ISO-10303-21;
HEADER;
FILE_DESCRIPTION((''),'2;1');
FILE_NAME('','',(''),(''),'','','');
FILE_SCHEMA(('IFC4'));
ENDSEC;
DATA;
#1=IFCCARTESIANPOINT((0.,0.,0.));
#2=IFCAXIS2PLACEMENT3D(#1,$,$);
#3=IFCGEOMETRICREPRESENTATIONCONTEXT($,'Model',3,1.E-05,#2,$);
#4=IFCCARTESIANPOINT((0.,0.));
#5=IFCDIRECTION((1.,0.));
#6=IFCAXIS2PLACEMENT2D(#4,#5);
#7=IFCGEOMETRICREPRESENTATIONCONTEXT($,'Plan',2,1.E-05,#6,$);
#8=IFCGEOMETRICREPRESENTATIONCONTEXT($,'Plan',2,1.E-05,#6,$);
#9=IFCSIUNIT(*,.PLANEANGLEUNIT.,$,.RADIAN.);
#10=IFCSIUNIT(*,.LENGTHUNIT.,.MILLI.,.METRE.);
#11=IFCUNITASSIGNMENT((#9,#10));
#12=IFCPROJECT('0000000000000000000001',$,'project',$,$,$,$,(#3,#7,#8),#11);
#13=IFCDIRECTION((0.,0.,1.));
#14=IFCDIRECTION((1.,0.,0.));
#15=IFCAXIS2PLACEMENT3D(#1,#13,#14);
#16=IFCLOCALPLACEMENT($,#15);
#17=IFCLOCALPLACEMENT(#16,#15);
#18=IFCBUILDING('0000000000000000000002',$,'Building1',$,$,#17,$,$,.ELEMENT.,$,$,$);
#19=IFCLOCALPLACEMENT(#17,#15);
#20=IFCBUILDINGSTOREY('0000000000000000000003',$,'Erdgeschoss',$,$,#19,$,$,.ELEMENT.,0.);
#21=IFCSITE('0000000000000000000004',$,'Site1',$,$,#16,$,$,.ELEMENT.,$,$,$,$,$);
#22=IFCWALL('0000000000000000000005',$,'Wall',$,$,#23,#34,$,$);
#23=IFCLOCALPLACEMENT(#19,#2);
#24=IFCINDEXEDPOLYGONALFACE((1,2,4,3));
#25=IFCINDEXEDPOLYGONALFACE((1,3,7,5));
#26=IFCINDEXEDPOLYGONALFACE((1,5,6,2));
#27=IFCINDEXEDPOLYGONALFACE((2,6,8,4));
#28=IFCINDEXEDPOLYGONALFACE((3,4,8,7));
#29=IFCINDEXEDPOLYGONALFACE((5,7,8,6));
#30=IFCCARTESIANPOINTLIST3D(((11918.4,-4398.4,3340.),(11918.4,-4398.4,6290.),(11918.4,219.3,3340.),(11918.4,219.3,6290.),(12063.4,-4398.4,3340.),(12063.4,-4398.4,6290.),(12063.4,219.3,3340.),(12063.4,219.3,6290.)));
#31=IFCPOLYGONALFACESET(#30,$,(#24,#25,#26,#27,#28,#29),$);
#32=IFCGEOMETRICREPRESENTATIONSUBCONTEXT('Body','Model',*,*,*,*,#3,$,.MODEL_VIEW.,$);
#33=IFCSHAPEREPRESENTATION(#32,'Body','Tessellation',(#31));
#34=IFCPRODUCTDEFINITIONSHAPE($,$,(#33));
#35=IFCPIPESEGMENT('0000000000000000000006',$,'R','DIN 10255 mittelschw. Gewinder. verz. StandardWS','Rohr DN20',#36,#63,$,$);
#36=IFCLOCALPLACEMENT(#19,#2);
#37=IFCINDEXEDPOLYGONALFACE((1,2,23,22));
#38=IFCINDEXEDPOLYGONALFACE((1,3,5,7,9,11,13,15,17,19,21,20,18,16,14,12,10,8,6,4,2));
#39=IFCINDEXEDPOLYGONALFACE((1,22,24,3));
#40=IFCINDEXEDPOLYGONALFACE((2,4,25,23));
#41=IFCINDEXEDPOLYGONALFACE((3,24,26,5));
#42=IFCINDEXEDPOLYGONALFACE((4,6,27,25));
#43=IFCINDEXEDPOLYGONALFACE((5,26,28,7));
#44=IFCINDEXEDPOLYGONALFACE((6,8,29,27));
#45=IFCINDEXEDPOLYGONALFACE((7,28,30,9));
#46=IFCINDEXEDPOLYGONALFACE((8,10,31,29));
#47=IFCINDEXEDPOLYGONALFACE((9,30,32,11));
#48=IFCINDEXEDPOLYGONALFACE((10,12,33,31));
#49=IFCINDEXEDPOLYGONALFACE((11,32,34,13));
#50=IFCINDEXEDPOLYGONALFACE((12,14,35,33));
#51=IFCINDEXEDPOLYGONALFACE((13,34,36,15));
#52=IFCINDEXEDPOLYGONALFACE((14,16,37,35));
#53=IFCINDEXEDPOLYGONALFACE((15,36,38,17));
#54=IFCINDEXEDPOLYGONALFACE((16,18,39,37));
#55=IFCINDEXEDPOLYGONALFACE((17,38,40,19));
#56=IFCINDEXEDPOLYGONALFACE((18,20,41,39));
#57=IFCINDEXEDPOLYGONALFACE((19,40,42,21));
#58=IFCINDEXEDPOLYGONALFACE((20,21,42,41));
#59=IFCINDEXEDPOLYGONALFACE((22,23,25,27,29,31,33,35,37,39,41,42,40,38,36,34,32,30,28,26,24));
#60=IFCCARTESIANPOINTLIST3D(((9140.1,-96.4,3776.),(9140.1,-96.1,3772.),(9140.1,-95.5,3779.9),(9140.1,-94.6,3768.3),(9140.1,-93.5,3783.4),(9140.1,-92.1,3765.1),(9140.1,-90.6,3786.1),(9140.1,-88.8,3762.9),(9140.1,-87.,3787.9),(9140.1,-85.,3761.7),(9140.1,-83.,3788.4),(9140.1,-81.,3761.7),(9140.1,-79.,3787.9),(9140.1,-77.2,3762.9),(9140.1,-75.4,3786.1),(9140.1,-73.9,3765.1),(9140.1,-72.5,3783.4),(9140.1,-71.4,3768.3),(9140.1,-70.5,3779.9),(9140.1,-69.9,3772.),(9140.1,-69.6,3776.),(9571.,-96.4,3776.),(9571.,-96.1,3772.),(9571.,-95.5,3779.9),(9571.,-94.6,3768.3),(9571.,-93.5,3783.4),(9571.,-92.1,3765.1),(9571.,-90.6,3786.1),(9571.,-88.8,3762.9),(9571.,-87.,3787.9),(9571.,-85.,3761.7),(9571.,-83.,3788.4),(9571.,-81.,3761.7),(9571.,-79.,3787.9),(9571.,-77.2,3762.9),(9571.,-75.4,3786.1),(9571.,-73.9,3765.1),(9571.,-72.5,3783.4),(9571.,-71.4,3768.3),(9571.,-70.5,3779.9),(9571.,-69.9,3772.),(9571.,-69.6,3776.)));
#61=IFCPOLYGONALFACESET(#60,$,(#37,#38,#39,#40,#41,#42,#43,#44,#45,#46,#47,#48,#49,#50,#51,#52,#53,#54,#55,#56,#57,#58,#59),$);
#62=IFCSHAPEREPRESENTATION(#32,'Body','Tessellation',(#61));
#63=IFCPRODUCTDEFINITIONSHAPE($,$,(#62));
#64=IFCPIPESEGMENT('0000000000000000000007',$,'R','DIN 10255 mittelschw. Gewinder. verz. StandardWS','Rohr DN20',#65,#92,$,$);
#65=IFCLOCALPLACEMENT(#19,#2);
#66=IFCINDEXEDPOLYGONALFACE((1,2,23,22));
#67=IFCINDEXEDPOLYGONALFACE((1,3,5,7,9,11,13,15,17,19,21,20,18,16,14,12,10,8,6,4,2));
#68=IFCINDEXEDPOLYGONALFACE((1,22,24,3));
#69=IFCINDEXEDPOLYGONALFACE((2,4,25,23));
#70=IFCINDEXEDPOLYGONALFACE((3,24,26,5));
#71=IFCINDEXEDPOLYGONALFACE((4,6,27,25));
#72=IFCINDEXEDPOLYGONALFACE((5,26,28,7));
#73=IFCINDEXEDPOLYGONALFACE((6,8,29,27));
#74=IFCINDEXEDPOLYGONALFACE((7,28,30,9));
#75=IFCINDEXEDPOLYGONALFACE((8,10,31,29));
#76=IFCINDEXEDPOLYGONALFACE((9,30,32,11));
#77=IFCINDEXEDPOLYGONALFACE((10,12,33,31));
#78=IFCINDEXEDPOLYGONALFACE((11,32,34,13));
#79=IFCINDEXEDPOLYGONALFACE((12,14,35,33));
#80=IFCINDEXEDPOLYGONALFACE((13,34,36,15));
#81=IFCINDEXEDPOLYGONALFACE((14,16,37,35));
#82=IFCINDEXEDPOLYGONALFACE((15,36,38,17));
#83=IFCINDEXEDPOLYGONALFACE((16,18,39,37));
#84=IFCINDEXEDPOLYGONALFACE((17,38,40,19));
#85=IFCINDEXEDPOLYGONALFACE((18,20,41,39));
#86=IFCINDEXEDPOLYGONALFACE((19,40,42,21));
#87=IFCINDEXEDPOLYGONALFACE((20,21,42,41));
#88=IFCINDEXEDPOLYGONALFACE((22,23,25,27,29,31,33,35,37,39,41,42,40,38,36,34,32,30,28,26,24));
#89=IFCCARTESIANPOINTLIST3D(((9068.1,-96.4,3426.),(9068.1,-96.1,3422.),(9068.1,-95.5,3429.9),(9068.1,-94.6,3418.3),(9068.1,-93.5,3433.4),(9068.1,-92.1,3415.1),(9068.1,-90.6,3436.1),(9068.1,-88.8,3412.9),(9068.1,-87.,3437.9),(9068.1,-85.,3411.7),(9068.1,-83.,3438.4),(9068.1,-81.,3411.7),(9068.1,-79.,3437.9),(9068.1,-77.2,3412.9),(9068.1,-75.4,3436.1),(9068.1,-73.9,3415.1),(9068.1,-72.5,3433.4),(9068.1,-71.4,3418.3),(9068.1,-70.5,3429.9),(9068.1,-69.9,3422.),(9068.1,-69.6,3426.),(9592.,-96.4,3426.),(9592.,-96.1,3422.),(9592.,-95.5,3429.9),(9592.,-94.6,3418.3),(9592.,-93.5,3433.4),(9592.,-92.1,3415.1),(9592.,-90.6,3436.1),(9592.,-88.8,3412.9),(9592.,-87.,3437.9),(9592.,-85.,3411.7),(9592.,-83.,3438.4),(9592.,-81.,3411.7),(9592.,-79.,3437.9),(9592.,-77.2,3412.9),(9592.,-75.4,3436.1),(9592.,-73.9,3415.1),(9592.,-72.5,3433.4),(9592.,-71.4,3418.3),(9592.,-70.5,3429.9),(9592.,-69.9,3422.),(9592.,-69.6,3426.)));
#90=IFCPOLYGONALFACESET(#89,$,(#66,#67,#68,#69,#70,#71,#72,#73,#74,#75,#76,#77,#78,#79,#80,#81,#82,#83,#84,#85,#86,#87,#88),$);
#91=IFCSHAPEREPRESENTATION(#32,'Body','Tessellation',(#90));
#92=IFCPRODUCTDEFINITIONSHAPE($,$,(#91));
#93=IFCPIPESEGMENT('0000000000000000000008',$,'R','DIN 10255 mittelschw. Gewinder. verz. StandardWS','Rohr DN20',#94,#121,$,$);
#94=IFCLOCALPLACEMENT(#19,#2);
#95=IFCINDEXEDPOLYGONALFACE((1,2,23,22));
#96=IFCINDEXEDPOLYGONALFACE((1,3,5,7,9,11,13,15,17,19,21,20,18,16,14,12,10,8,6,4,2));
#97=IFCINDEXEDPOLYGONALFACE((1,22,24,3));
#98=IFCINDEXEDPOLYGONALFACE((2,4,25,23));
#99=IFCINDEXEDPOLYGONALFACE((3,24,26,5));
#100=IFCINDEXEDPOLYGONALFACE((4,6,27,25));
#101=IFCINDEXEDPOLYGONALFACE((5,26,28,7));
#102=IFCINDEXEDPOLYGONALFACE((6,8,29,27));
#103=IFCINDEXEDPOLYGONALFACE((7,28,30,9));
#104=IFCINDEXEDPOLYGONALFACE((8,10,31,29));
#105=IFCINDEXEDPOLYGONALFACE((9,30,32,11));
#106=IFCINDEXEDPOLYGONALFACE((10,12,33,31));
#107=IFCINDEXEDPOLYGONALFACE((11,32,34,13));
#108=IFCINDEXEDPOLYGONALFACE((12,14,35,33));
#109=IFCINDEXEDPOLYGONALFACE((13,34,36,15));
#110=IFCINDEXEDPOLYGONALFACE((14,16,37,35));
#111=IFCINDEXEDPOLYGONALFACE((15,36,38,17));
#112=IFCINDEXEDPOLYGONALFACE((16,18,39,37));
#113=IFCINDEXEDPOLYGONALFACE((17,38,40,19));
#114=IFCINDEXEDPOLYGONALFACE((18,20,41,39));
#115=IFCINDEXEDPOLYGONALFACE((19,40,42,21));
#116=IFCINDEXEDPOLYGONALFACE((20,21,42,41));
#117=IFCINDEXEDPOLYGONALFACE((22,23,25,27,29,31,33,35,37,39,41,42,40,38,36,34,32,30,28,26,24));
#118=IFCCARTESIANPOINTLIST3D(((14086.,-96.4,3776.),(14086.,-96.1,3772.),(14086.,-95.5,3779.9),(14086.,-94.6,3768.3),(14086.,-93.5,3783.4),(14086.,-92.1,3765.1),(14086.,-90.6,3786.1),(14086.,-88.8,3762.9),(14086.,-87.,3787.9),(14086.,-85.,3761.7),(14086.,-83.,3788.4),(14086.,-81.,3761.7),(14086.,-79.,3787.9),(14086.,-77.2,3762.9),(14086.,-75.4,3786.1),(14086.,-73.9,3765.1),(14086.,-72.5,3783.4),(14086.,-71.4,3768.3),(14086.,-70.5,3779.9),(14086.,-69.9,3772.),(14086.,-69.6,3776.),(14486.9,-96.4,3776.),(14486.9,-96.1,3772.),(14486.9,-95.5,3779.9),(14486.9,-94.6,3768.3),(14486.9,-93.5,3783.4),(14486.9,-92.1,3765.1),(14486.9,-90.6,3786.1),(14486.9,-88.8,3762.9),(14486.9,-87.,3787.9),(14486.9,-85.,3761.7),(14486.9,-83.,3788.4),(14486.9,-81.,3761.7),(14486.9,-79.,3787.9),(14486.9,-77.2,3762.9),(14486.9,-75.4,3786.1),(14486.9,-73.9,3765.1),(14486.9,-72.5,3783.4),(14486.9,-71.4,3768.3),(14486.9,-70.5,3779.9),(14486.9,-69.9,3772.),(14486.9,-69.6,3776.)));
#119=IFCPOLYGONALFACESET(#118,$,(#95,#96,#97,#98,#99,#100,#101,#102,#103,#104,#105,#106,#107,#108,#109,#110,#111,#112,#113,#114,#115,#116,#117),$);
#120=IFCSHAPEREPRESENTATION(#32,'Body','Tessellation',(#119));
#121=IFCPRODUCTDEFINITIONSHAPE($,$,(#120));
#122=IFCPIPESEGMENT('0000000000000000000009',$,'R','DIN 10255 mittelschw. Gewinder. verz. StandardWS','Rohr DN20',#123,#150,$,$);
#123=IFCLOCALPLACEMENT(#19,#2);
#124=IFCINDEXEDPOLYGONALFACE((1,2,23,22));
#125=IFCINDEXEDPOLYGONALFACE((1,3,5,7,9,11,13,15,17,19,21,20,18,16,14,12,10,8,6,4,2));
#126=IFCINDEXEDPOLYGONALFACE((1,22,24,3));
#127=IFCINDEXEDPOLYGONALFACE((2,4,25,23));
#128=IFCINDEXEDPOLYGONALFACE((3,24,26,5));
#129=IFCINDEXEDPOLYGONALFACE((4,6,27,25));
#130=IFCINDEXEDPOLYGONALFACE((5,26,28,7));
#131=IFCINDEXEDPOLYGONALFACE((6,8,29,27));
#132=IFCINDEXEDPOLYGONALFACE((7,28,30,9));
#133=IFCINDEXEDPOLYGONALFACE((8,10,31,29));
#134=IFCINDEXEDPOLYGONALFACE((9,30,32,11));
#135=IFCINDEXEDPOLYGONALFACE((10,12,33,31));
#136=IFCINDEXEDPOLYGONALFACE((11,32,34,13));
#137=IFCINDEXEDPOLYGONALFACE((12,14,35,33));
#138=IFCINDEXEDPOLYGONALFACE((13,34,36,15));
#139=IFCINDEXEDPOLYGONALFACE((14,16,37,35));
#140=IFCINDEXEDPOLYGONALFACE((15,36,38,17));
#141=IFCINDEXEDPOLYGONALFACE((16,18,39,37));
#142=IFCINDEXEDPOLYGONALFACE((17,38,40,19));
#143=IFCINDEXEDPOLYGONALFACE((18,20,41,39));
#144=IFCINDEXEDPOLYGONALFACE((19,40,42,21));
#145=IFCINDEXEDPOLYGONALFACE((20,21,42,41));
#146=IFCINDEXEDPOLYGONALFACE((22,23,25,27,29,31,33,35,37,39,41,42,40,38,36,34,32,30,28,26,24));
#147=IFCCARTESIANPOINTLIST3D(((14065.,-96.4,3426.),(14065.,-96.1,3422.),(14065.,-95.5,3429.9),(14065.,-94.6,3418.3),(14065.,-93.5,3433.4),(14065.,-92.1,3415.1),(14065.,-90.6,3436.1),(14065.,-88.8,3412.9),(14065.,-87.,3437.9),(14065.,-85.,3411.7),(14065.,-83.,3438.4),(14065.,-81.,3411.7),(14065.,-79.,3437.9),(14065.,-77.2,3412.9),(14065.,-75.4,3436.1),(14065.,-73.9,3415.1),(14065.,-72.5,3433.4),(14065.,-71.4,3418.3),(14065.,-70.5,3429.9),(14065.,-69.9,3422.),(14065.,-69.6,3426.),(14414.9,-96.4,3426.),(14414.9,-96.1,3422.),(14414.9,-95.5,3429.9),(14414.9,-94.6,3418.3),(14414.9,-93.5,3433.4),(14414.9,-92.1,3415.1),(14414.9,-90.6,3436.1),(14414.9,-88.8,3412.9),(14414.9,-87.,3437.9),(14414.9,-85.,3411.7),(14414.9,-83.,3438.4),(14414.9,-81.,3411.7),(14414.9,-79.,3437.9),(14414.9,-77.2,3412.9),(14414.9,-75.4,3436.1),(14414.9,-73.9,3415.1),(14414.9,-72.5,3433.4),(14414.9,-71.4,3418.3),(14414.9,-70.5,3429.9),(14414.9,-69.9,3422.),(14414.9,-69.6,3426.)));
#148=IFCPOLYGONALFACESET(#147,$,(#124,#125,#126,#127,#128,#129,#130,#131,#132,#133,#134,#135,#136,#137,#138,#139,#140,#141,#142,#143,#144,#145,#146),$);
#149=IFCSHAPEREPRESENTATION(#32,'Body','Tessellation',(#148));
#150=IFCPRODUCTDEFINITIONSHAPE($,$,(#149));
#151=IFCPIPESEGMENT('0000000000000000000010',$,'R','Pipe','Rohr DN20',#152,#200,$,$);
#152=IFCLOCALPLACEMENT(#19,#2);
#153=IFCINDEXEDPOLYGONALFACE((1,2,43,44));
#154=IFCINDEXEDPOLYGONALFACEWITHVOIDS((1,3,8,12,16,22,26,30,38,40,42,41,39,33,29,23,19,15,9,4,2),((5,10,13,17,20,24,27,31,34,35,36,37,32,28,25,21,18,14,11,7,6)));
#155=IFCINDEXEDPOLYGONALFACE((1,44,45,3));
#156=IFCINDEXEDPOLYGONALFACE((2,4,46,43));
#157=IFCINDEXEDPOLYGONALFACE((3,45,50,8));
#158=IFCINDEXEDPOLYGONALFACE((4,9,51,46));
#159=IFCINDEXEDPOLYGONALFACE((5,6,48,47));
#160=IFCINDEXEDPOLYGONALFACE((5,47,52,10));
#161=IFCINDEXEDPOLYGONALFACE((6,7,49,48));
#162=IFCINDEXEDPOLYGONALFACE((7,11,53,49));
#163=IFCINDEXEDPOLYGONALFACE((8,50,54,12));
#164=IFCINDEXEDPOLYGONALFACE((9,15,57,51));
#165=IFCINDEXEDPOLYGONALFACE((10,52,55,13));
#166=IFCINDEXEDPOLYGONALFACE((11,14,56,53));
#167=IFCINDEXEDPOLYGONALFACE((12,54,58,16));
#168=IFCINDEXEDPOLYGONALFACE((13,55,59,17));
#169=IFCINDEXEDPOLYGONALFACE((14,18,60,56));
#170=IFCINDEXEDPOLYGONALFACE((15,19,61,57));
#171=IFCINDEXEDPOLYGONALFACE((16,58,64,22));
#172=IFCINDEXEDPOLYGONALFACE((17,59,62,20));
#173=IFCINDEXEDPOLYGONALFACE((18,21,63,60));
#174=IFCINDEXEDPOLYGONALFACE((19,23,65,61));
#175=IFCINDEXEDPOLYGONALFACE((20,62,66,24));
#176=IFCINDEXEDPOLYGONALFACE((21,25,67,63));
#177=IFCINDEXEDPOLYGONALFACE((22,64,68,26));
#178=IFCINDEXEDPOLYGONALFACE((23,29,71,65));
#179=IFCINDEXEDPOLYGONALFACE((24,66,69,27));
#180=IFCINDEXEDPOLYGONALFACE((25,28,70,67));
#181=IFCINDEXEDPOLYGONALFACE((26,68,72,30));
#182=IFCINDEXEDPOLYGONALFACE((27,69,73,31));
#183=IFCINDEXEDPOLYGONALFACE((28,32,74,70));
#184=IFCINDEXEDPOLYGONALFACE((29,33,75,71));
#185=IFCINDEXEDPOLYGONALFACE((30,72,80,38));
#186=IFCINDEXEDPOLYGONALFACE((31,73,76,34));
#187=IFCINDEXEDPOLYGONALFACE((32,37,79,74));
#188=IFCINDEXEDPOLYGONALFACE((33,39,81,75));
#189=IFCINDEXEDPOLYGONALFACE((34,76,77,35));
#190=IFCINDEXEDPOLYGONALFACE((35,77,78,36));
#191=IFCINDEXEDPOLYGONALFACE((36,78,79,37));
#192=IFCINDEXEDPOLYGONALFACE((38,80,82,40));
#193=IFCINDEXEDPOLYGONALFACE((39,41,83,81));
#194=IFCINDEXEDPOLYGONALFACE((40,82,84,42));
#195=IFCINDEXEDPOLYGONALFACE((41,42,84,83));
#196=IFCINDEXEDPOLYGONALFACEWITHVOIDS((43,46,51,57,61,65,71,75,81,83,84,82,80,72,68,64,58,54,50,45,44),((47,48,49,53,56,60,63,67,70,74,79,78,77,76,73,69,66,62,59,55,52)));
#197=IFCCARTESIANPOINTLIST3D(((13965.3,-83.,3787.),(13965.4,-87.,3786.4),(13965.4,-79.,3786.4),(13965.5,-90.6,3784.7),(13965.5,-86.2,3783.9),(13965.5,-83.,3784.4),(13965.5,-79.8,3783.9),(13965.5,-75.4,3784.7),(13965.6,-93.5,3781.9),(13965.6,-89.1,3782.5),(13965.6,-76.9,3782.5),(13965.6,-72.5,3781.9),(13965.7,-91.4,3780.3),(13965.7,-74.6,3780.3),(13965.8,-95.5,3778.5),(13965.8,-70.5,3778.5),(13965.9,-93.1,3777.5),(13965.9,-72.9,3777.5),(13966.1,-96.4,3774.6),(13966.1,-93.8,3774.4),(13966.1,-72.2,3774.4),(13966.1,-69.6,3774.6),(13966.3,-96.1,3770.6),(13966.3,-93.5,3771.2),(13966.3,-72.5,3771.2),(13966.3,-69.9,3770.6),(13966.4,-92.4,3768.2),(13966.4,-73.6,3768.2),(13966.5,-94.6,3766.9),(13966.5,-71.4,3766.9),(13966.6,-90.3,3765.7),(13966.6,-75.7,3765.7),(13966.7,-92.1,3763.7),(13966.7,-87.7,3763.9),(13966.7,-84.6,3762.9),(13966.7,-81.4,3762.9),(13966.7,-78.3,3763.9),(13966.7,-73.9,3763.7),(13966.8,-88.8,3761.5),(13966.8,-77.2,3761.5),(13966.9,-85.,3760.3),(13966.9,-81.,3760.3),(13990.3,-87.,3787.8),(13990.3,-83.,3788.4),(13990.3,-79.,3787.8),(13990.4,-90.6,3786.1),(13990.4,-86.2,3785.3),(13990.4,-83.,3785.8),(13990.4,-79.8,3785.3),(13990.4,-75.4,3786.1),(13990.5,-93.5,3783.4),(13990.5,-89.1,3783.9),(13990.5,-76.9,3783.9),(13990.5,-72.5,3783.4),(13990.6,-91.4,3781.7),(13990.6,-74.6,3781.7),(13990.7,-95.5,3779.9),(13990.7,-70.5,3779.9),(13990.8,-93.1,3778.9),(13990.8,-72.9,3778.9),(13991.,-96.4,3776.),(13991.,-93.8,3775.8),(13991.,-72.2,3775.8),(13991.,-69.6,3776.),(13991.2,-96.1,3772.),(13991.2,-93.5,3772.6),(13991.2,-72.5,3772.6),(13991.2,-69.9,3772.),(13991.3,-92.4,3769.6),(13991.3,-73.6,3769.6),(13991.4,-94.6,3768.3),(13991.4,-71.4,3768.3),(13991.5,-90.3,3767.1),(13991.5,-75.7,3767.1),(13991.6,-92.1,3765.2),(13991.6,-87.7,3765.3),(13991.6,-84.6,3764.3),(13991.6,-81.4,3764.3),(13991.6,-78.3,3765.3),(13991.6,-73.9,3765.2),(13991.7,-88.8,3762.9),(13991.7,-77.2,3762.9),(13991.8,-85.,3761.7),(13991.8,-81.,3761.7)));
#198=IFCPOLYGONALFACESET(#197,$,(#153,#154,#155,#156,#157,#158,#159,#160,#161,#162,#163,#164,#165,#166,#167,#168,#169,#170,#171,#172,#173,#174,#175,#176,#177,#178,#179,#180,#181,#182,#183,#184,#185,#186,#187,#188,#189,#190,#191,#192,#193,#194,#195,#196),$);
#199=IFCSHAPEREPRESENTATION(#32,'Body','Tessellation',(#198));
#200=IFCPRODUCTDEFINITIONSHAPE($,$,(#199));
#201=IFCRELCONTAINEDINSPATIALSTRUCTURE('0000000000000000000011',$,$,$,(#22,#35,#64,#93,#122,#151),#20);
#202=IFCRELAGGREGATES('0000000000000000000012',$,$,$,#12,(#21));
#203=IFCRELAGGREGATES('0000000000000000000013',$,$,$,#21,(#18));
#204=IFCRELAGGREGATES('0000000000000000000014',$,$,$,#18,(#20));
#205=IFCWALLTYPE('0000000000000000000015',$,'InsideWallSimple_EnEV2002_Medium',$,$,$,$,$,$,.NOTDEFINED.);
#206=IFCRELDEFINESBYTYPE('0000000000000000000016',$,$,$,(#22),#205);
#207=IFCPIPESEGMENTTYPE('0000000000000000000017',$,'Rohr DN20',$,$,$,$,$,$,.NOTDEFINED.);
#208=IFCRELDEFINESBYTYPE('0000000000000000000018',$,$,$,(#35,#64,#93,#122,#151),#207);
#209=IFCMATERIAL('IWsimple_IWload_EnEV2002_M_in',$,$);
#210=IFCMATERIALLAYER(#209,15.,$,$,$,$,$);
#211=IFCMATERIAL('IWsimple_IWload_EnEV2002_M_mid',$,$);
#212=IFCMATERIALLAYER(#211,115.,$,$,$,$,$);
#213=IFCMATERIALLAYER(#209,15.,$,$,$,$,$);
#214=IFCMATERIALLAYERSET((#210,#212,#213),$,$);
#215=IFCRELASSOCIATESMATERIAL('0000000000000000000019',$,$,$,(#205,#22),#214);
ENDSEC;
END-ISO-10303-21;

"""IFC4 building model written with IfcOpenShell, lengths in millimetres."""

from ifc_helpers import new_model, si_unit, frame, origin, origin_with_axes, origin_2d_with_axis, place, context, subcontext, project, spatial, indexed_curve, circle, hollow_circle, outline, extrude, material, layer, layer_set, layer_usage, type_object, element, save


model = new_model("IFC4")

# Units and contexts
model_context = context("Model", 3, precision=1e-05, world=origin())
plan_context_1 = context("Plan", 2, precision=1e-05, world=origin_2d_with_axis())
plan_context_2 = context("Plan", 2, precision=1e-05, world=origin_2d_with_axis())
body_context = subcontext(model_context, "Body", "Model", "MODEL_VIEW")
ifc_project = project(units=[si_unit("PLANEANGLEUNIT", "RADIAN"), si_unit("LENGTHUNIT", "METRE", prefix="MILLI")], contexts=[model_context, plan_context_1, plan_context_2])

# Site, building, storey
site_placement = place(None, origin_with_axes())
site = spatial("IfcSite", under=ifc_project, at=site_placement, Name="Site1", CompositionType="ELEMENT")
building_placement = place(site_placement, origin_with_axes())
building = spatial("IfcBuilding", under=site, at=building_placement, Name="Building1", CompositionType="ELEMENT")
storey_placement = place(building_placement, origin_with_axes())
storey = spatial("IfcBuildingStorey", under=building, at=storey_placement, Name="Erdgeschoss", CompositionType="ELEMENT", Elevation=0.0)

# Wall
ifc_material_1 = material(Name="IWsimple_IWload_EnEV2002_M_in")
ifc_layer_1 = layer(ifc_material_1, 15.0)
ifc_material_2 = material(Name="IWsimple_IWload_EnEV2002_M_mid")
ifc_layer_2 = layer(ifc_material_2, 115.0)
ifc_layer_3 = layer(ifc_material_1, 15.0)
ifc_layer_set = layer_set([ifc_layer_1, ifc_layer_2, ifc_layer_3])
ifc_layer_usage = layer_usage(ifc_layer_set, "AXIS2", "POSITIVE", 0.0)
wall_type = type_object("IfcWallType", Name="InsideWallSimple_EnEV2002_Medium", PredefinedType="NOTDEFINED", material=ifc_layer_set)
wall_placement = place(storey_placement, frame((11918.4, 219.3, 3340.0), z_axis=(0.0, 0.0, 1.0), x_axis=(-0.000001, -1.0, 0.0)))
element("IfcWall", 1, at=wall_placement, inside=storey, type_object=wall_type, material=ifc_layer_usage, Name="Wall", context=body_context, shape_type="SweptSolid", body=[
    extrude(outline(indexed_curve([(0.0, 0.0), (0.0, 145.0), (4617.6, 145.0), (4617.6, 0.0), (0.0, 0.0)], self_intersect=False)), origin_with_axes(), (0.0, 0.0, 1.0), 2950.0),
])

# Pipe segments
pipe_segment_type_1 = type_object("IfcPipeSegmentType", Name="Rohr DN20", PredefinedType="NOTDEFINED")
pipe_segment_1_placement = place(storey_placement, frame((9355.6, -83.2, 3775.0), z_axis=(0.0, 0.0, 1.0), x_axis=(1.0, 0.0, 0.0)))
element("IfcPipeSegment", 2, at=pipe_segment_1_placement, inside=storey, type_object=pipe_segment_type_1, Name="R", Description="DIN 10255 mittelschw. Gewinder. verz. StandardWS", ObjectType="Rohr DN20", context=body_context, shape_type="SolidModel", body=[
    extrude(circle(Radius=13.4, at=origin_2d_with_axis()), frame((215.5, 0.2, 0.0), z_axis=(-1.0, 0.0, 0.0), x_axis=(0.0, 0.0, 1.0)), (0.0, 0.0, 1.0), 430.9),
])
pipe_segment_2_placement = place(storey_placement, frame((9330.1, -83.2, 3425.0), z_axis=(0.0, 0.0, 1.0), x_axis=(1.0, 0.0, 0.0)))
element("IfcPipeSegment", 3, at=pipe_segment_2_placement, inside=storey, type_object=pipe_segment_type_1, Name="R", Description="DIN 10255 mittelschw. Gewinder. verz. StandardWS", ObjectType="Rohr DN20", context=body_context, shape_type="SolidModel", body=[
    extrude(circle(Radius=13.4, at=origin_2d_with_axis()), frame((262.0, 0.2, 0.0), z_axis=(-1.0, 0.0, 0.0), x_axis=(0.0, 0.0, 1.0)), (0.0, 0.0, 1.0), 523.9),
])
pipe_segment_3_placement = place(storey_placement, frame((14286.5, -83.2, 3775.0), z_axis=(0.0, 0.0, 1.0), x_axis=(1.0, 0.0, 0.0)))
element("IfcPipeSegment", 4, at=pipe_segment_3_placement, inside=storey, type_object=pipe_segment_type_1, Name="R", Description="DIN 10255 mittelschw. Gewinder. verz. StandardWS", ObjectType="Rohr DN20", context=body_context, shape_type="SolidModel", body=[
    extrude(circle(Radius=13.4, at=origin_2d_with_axis()), frame((200.5, 0.1, 0.0), z_axis=(-1.0, 0.0, 0.0), x_axis=(0.0, 0.0, 1.0)), (0.0, 0.0, 1.0), 400.9),
])
pipe_segment_4_placement = place(storey_placement, frame((14240.0, -83.2, 3425.0), z_axis=(0.0, 0.0, 1.0), x_axis=(1.0, 0.0, 0.0)))
element("IfcPipeSegment", 5, at=pipe_segment_4_placement, inside=storey, type_object=pipe_segment_type_1, Name="R", Description="DIN 10255 mittelschw. Gewinder. verz. StandardWS", ObjectType="Rohr DN20", context=body_context, shape_type="SolidModel", body=[
    extrude(circle(Radius=13.4, at=origin_2d_with_axis()), frame((175.0, 0.2, 0.0), z_axis=(-1.0, 0.0, 0.0), x_axis=(0.0, 0.0, 1.0)), (0.0, 0.0, 1.0), 349.9),
])
pipe_segment_5_placement = place(storey_placement, frame((13978.6, -82.8, 3774.3), z_axis=(0.0, 0.0, 1.0), x_axis=(1.0, 0.0, 0.0)))
element("IfcPipeSegment", 6, at=pipe_segment_5_placement, inside=storey, type_object=pipe_segment_type_1, Name="R", Description="Pipe", ObjectType="Rohr DN20", context=body_context, shape_type="SolidModel", body=[
    extrude(hollow_circle(Radius=13.4, WallThickness=2.6, at=origin_2d_with_axis()), frame((-12.5, -0.1, -0.7), z_axis=(0.998368, 0.0, 0.057114), x_axis=(0.0, 0.0, 1.0)), (0.0, 0.0, 1.0), 24.9),
])

save(model, "model.ifc")
